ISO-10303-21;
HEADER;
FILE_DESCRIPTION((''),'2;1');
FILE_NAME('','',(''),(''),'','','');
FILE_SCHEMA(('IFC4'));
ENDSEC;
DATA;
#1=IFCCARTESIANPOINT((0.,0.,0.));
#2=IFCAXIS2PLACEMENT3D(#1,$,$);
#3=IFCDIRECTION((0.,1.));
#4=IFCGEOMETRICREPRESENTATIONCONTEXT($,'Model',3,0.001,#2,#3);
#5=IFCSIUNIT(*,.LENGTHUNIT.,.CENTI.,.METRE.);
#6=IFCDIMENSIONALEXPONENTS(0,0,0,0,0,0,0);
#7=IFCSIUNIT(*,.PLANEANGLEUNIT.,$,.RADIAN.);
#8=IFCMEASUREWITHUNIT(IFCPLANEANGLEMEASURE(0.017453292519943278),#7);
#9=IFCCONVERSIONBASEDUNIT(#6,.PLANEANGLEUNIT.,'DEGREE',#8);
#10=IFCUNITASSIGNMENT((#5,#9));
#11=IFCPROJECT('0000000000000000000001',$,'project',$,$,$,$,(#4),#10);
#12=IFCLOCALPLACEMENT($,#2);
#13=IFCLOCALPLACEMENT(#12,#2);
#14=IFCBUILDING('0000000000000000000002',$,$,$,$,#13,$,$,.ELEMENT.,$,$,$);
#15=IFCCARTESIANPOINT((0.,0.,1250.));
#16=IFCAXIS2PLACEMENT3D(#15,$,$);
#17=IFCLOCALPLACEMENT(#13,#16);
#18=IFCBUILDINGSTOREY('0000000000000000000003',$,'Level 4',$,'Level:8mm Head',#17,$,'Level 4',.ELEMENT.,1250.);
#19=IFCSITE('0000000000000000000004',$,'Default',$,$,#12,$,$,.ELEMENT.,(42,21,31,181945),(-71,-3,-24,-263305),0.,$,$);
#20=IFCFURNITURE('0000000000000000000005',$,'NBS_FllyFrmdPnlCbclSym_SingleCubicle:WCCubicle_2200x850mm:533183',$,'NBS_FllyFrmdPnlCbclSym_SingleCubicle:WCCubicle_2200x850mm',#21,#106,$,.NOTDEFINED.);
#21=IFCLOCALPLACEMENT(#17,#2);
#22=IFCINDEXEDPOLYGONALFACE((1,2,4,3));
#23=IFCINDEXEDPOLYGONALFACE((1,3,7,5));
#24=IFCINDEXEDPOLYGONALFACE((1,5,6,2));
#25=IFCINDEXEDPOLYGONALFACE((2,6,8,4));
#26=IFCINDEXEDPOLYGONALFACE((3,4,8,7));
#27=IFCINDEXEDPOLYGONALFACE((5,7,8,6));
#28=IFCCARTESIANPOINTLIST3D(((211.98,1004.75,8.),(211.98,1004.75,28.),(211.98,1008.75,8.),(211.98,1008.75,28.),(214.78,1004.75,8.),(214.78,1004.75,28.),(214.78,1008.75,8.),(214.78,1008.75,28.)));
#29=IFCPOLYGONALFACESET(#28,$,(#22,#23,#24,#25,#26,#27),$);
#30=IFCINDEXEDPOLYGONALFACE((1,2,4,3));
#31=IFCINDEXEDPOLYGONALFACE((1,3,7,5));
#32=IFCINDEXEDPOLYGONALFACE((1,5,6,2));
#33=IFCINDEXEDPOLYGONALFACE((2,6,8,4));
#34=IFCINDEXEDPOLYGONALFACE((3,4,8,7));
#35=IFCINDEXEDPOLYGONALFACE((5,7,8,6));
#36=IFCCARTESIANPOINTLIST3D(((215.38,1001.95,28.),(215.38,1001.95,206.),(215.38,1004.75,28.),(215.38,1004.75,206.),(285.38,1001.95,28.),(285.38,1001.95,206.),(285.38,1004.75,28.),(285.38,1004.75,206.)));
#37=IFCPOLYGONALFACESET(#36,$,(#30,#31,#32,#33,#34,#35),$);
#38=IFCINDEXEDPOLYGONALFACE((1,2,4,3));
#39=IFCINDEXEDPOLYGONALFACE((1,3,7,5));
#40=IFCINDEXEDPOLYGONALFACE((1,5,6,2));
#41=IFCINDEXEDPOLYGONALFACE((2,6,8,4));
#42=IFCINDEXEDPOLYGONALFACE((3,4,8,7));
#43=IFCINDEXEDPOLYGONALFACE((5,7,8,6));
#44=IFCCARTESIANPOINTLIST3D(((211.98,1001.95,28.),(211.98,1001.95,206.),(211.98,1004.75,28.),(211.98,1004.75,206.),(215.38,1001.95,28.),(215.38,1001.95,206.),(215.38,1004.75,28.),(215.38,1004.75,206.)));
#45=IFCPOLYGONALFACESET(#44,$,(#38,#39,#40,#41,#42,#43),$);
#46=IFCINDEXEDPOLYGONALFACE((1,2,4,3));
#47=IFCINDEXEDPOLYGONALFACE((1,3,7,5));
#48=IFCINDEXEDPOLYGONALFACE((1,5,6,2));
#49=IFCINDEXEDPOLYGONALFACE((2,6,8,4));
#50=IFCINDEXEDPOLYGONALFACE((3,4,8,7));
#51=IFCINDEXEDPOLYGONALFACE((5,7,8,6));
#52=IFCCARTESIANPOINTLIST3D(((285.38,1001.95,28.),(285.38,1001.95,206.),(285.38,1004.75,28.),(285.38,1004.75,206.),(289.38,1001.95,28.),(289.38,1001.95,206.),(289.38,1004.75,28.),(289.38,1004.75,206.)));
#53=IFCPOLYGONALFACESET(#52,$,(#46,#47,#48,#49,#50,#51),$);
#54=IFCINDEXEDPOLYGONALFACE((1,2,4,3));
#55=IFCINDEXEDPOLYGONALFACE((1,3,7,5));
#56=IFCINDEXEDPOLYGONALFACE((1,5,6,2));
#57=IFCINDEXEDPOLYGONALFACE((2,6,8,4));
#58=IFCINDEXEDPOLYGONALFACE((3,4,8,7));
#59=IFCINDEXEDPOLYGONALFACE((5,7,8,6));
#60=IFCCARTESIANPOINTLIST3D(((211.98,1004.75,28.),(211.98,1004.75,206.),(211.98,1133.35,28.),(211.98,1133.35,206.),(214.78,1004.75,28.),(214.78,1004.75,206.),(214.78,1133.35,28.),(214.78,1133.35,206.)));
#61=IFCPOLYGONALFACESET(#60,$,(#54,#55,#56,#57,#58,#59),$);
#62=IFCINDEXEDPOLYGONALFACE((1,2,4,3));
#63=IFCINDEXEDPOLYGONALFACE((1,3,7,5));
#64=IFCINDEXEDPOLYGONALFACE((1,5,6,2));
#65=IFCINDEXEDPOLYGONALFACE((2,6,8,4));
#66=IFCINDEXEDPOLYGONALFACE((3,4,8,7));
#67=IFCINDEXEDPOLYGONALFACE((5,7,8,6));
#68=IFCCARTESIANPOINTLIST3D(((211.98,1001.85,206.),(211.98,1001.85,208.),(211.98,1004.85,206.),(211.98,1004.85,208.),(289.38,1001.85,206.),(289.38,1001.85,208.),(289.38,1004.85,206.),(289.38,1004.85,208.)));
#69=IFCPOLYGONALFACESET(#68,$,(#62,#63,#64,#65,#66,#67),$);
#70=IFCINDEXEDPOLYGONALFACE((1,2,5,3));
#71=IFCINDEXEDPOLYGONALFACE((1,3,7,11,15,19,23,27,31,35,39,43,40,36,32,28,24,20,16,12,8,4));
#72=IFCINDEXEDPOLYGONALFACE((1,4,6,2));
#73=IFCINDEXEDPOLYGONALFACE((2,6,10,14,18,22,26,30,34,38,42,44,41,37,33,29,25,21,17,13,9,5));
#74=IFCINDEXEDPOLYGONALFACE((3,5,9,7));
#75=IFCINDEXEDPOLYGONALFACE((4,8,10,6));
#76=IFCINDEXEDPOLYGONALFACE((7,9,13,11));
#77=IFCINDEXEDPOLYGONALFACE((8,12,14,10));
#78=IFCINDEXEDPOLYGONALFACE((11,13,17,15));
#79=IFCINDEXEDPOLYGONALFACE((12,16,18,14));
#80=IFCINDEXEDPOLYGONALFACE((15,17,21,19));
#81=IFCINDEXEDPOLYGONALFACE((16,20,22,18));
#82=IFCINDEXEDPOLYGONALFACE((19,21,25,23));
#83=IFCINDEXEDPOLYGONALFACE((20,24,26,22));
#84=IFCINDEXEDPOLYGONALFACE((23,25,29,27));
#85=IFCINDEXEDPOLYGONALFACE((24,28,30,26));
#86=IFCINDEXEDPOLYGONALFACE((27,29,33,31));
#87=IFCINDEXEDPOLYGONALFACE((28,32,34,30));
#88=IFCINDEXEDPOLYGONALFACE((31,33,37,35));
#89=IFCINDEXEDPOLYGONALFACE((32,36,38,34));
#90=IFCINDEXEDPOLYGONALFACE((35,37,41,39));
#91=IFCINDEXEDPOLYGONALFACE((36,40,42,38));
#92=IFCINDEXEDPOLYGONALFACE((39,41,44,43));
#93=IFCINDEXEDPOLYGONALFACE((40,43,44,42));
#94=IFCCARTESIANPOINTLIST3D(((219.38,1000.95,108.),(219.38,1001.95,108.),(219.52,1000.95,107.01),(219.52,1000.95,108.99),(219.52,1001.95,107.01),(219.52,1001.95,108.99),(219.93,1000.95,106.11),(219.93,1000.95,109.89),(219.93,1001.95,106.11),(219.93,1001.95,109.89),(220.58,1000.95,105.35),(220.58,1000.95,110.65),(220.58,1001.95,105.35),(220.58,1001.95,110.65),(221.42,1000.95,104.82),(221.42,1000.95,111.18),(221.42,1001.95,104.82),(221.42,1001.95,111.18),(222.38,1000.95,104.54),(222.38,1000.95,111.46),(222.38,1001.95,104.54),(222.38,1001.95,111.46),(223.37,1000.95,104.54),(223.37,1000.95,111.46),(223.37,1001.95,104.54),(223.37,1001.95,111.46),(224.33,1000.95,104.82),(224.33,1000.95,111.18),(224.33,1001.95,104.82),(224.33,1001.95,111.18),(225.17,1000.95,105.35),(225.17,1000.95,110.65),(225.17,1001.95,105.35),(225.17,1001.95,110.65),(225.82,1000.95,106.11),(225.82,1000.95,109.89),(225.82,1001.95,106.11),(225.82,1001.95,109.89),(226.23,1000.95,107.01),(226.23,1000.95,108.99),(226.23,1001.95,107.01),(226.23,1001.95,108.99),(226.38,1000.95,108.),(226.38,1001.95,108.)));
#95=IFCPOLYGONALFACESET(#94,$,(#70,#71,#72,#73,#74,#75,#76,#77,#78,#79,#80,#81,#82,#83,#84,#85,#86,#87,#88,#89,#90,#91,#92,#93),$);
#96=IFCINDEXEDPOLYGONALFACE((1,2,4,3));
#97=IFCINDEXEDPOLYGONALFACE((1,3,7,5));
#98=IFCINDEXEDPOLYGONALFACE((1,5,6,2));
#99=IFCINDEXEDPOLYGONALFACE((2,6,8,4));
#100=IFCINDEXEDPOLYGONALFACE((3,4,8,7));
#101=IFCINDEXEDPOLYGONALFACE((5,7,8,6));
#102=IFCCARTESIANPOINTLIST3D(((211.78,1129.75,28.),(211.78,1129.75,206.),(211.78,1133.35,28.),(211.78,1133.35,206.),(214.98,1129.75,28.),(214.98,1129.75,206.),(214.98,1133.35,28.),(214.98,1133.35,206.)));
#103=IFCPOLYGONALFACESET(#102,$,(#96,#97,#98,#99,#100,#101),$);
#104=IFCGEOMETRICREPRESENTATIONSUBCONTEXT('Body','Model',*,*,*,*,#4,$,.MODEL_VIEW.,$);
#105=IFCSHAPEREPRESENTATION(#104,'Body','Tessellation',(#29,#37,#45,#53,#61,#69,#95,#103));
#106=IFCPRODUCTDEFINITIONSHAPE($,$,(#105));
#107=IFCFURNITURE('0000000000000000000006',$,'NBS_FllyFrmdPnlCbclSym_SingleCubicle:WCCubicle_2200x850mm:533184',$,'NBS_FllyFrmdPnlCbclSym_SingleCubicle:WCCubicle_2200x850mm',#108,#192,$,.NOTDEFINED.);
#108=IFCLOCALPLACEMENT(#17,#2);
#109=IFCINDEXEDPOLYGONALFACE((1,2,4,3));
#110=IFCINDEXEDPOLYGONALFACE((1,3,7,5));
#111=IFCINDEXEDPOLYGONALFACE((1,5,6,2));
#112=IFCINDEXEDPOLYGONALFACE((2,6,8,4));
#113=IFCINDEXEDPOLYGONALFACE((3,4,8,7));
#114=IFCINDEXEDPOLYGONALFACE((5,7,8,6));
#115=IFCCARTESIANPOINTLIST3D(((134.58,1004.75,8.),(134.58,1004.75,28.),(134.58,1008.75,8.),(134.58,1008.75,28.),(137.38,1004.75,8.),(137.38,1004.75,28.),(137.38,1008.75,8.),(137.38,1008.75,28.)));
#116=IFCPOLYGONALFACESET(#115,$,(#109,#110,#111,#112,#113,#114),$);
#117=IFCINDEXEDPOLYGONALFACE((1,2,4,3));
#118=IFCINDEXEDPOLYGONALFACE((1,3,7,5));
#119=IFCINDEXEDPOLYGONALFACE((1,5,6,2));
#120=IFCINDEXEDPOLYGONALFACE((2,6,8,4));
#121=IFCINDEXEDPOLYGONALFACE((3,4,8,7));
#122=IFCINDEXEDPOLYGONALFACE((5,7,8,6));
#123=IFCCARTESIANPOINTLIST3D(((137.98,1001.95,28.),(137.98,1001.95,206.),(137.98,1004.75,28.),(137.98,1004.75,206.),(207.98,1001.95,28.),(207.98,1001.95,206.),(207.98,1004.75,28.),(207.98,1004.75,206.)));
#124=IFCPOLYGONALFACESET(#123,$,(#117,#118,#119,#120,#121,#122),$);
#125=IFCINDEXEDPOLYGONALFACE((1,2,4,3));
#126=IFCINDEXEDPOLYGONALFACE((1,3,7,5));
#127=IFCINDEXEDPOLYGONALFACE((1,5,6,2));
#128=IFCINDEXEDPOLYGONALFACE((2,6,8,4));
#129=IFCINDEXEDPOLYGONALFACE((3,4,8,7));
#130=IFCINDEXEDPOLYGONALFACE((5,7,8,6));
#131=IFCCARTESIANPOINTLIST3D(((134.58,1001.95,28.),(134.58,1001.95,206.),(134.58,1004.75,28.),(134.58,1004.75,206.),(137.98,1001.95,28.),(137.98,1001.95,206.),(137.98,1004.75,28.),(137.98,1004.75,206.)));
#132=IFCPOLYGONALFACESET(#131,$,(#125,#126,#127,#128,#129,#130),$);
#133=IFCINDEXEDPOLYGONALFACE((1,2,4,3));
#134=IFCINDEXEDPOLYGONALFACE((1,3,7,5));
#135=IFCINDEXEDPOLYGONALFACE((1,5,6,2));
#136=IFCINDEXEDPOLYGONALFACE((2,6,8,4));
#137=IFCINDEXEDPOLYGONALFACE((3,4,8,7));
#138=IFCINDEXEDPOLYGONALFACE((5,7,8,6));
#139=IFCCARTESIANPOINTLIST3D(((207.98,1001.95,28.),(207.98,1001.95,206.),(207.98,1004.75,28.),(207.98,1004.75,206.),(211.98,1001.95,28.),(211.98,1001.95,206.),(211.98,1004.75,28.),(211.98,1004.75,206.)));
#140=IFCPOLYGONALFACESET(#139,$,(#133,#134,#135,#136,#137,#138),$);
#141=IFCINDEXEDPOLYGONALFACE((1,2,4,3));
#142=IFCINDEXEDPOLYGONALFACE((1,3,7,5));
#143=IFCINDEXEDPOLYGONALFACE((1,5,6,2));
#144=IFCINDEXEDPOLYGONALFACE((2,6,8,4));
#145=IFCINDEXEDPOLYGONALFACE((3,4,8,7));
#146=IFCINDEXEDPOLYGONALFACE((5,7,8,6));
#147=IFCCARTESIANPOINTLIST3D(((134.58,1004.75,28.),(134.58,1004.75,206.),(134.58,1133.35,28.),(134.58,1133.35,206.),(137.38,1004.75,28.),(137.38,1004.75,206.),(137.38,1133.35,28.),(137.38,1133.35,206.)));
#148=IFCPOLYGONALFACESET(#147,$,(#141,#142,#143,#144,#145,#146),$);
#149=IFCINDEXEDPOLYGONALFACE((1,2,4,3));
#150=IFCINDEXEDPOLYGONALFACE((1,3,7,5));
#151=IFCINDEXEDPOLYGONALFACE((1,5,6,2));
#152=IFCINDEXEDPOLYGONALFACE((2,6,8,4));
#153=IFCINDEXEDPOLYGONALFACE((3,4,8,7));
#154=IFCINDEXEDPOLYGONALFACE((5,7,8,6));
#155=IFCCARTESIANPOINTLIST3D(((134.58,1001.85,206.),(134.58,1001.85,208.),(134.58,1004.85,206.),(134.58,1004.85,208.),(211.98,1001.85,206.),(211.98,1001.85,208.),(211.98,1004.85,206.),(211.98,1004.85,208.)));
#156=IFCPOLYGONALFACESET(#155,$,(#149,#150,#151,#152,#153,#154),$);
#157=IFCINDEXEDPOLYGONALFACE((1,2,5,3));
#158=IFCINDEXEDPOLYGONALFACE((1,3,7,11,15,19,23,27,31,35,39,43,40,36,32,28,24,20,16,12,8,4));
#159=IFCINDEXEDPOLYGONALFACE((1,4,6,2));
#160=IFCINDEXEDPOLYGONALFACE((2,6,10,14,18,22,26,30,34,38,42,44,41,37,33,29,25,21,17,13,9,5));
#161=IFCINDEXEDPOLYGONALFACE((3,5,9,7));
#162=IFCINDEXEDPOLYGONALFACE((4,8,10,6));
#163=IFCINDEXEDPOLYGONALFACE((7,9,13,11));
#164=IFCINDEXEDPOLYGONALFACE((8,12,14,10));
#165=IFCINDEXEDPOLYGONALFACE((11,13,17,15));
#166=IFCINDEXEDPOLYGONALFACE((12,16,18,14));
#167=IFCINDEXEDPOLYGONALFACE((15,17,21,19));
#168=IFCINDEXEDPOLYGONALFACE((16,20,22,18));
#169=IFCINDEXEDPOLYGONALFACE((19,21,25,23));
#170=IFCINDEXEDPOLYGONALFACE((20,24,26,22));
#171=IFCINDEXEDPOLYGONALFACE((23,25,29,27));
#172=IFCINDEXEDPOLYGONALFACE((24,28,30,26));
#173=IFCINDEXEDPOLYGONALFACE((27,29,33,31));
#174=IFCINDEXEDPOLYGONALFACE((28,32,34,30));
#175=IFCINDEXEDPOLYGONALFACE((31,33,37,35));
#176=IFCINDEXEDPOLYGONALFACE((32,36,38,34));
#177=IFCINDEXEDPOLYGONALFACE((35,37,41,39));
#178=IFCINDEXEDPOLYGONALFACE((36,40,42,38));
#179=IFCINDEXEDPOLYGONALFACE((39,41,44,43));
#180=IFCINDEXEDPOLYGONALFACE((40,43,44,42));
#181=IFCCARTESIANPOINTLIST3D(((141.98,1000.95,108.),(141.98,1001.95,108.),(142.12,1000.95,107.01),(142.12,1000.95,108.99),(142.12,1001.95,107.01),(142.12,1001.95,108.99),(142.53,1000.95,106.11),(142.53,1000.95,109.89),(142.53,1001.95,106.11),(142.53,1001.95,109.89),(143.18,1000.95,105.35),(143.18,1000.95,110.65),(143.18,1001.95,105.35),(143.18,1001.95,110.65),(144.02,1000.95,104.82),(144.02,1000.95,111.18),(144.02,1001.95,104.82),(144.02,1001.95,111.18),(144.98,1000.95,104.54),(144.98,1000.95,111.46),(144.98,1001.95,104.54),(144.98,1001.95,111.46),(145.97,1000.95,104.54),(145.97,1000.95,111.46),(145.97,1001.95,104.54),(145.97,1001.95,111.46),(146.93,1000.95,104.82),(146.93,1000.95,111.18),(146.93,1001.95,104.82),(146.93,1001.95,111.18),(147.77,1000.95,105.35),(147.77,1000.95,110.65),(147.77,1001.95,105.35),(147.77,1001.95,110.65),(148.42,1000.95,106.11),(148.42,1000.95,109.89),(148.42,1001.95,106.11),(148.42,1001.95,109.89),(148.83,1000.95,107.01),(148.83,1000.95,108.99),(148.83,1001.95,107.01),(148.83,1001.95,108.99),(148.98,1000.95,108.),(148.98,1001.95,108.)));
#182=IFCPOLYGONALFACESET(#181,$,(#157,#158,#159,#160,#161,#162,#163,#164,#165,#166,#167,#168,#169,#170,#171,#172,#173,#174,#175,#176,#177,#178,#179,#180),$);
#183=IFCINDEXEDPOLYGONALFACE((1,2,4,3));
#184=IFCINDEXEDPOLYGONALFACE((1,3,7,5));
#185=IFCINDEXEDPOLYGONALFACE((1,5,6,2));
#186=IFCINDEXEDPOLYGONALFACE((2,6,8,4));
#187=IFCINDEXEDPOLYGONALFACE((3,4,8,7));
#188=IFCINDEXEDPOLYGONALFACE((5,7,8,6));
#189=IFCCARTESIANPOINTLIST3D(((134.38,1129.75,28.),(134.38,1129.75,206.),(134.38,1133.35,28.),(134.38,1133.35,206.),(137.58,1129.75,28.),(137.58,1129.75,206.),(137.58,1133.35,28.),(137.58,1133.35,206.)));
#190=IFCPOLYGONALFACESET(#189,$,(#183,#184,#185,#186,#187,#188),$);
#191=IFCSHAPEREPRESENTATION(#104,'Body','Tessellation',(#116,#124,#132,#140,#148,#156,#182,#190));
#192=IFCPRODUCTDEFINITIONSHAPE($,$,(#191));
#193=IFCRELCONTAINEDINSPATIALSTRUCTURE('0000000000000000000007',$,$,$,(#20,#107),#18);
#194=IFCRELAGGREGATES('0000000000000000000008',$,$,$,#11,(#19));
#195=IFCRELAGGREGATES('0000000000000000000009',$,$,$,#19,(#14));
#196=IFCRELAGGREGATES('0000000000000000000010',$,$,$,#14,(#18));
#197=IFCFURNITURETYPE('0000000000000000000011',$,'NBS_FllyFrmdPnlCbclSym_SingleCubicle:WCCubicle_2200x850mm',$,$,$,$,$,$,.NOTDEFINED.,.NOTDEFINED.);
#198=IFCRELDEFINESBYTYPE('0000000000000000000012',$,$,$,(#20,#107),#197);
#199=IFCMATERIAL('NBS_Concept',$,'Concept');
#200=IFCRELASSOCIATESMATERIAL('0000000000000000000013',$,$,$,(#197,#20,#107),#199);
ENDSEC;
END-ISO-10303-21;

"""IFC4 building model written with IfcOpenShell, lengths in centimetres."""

from ifc_helpers import new_model, entity, si_unit, converted_unit, direction, frame, origin, place, context, subcontext, project, spatial, arc, indexed_curve, outline, extrude, source, transform, mapped, material, type_object, type_shapes, element, save


model = new_model("IFC4")

# Units and contexts
model_context = context("Model", 3, precision=0.001, world=origin(), true_north=direction((0.0, 1.0)))
body_context = subcontext(model_context, "Body", "Model", "MODEL_VIEW")
ifc_project = project(units=[si_unit("LENGTHUNIT", "METRE", prefix="CENTI"), converted_unit("PLANEANGLEUNIT", "DEGREE", entity("IfcPlaneAngleMeasure", 0.017453292519943278), si_unit("PLANEANGLEUNIT", "RADIAN"), dimensions=[0, 0, 0, 0, 0, 0, 0])], contexts=[model_context])

# Site, building, storey
site_placement = place(None, origin())
site = spatial("IfcSite", under=ifc_project, at=site_placement, Name="Default", CompositionType="ELEMENT", RefLatitude=(42, 21, 31, 181945), RefLongitude=(-71, -3, -24, -263305), RefElevation=0.0)
building_placement = place(site_placement, origin())
building = spatial("IfcBuilding", under=site, at=building_placement, CompositionType="ELEMENT")
storey_placement = place(building_placement, frame((0.0, 0.0, 1250.0)))
storey = spatial("IfcBuildingStorey", under=building, at=storey_placement, Name="Level 4", ObjectType="Level:8mm Head", LongName="Level 4", CompositionType="ELEMENT", Elevation=1250.0)

# Furniture
ifc_material_1 = material(Name="NBS_Concept", Category="Concept")
furniture_type = type_object("IfcFurnitureType", Name="NBS_FllyFrmdPnlCbclSym_SingleCubicle:WCCubicle_2200x850mm", AssemblyPlace="NOTDEFINED", PredefinedType="NOTDEFINED", material=ifc_material_1)
shared_shape_1 = source(origin(), body_context, "Body", "SweptSolid", [
    extrude(outline(indexed_curve([(-2.0, -1.4), (2.0, -1.4), (2.0, 1.4), (-2.0, 1.4), (-2.0, -1.4)], self_intersect=False)), frame((37.0, 126.6, 0.0), z_axis=(0.0, 0.0, 1.0), x_axis=(0.0, 1.0, 0.0)), (0.0, 0.0, 1.0), 20.0),
    extrude(outline(indexed_curve([(-1.4, -35.0), (1.4, -35.0), (1.4, 35.0), (-1.4, 35.0), (-1.4, -35.0)], self_intersect=False)), frame((0.0, 130.0, 20.0), z_axis=(0.0, 0.0, 1.0), x_axis=(0.0, 1.0, 0.0)), (0.0, 0.0, 1.0), 178.0),
    extrude(outline(indexed_curve([(-1.4, -1.7), (1.4, -1.7), (1.4, 1.7), (-1.4, 1.7), (-1.4, -1.7)], self_intersect=False)), frame((36.7, 130.0, 20.0), z_axis=(0.0, 0.0, 1.0), x_axis=(0.0, 1.0, 0.0)), (0.0, 0.0, 1.0), 178.0),
    extrude(outline(indexed_curve([(-1.4, -2.0), (1.4, -2.0), (1.4, 2.0), (-1.4, 2.0), (-1.4, -2.0)], self_intersect=False)), frame((-37.0, 130.0, 20.0), z_axis=(0.0, 0.0, 1.0), x_axis=(0.0, 1.0, 0.0)), (0.0, 0.0, 1.0), 178.0),
    extrude(outline(indexed_curve([(-64.3, -1.4), (64.3, -1.4), (64.3, 1.4), (-64.3, 1.4), (-64.3, -1.4)], self_intersect=False)), frame((37.0, 64.3, 20.0), z_axis=(0.0, 0.0, 1.0), x_axis=(0.0, 1.0, 0.0)), (0.0, 0.0, 1.0), 178.0),
    extrude(outline(indexed_curve([(-1.5, -38.7), (1.5, -38.7), (1.5, 38.7), (-1.5, 38.7), (-1.5, -38.7)], self_intersect=False)), frame((-0.3, 130.0, 198.0), z_axis=(0.0, 0.0, 1.0), x_axis=(0.0, 1.0, 0.0)), (0.0, 0.0, 1.0), 2.0),
    extrude(outline(indexed_curve([(-3.5, 0.0), (0.0, -3.5), (3.5, 0.0), (0.0, 3.5)], segments=[arc(1, 2, 3), arc(3, 4, 1)], self_intersect=False)), frame((27.5, 131.4, 100.0), z_axis=(0.0, 1.0, 0.0), x_axis=(-1.0, 0.0, 0.0)), (0.0, 0.0, 1.0), 1.0),
    extrude(outline(indexed_curve([(-1.8, -1.6), (1.8, -1.6), (1.8, 1.6), (-1.8, 1.6), (-1.8, -1.6)], self_intersect=False)), frame((37.0, 1.8, 20.0), z_axis=(0.0, 0.0, 1.0), x_axis=(0.0, 1.0, 0.0)), (0.0, 0.0, 1.0), 178.0),
])
type_shapes(furniture_type, [shared_shape_1])
for number, where, z_axis, x_axis, name in (
    (1, (250.38, 1133.35, 8.0), (0.0, 0.0, 1.0), (-1.0, 0.0, 0.0), "NBS_FllyFrmdPnlCbclSym_SingleCubicle:WCCubicle_2200x850mm:533183"),
    (2, (172.98, 1133.35, 8.0), (0.0, 0.0, 1.0), (-1.0, 0.0, 0.0), "NBS_FllyFrmdPnlCbclSym_SingleCubicle:WCCubicle_2200x850mm:533184"),
):
    element("IfcFurniture", number, at=place(storey_placement, frame(where, z_axis=z_axis, x_axis=x_axis)), inside=storey, type_object=furniture_type, material=ifc_material_1, Name=name, ObjectType="NBS_FllyFrmdPnlCbclSym_SingleCubicle:WCCubicle_2200x850mm", PredefinedType="NOTDEFINED", context=body_context, shape_type="MappedRepresentation", body=[
        mapped(shared_shape_1, transform((0.0, 0.0, 0.0), scale=1.0)),
    ])

save(model, "model.ifc")
